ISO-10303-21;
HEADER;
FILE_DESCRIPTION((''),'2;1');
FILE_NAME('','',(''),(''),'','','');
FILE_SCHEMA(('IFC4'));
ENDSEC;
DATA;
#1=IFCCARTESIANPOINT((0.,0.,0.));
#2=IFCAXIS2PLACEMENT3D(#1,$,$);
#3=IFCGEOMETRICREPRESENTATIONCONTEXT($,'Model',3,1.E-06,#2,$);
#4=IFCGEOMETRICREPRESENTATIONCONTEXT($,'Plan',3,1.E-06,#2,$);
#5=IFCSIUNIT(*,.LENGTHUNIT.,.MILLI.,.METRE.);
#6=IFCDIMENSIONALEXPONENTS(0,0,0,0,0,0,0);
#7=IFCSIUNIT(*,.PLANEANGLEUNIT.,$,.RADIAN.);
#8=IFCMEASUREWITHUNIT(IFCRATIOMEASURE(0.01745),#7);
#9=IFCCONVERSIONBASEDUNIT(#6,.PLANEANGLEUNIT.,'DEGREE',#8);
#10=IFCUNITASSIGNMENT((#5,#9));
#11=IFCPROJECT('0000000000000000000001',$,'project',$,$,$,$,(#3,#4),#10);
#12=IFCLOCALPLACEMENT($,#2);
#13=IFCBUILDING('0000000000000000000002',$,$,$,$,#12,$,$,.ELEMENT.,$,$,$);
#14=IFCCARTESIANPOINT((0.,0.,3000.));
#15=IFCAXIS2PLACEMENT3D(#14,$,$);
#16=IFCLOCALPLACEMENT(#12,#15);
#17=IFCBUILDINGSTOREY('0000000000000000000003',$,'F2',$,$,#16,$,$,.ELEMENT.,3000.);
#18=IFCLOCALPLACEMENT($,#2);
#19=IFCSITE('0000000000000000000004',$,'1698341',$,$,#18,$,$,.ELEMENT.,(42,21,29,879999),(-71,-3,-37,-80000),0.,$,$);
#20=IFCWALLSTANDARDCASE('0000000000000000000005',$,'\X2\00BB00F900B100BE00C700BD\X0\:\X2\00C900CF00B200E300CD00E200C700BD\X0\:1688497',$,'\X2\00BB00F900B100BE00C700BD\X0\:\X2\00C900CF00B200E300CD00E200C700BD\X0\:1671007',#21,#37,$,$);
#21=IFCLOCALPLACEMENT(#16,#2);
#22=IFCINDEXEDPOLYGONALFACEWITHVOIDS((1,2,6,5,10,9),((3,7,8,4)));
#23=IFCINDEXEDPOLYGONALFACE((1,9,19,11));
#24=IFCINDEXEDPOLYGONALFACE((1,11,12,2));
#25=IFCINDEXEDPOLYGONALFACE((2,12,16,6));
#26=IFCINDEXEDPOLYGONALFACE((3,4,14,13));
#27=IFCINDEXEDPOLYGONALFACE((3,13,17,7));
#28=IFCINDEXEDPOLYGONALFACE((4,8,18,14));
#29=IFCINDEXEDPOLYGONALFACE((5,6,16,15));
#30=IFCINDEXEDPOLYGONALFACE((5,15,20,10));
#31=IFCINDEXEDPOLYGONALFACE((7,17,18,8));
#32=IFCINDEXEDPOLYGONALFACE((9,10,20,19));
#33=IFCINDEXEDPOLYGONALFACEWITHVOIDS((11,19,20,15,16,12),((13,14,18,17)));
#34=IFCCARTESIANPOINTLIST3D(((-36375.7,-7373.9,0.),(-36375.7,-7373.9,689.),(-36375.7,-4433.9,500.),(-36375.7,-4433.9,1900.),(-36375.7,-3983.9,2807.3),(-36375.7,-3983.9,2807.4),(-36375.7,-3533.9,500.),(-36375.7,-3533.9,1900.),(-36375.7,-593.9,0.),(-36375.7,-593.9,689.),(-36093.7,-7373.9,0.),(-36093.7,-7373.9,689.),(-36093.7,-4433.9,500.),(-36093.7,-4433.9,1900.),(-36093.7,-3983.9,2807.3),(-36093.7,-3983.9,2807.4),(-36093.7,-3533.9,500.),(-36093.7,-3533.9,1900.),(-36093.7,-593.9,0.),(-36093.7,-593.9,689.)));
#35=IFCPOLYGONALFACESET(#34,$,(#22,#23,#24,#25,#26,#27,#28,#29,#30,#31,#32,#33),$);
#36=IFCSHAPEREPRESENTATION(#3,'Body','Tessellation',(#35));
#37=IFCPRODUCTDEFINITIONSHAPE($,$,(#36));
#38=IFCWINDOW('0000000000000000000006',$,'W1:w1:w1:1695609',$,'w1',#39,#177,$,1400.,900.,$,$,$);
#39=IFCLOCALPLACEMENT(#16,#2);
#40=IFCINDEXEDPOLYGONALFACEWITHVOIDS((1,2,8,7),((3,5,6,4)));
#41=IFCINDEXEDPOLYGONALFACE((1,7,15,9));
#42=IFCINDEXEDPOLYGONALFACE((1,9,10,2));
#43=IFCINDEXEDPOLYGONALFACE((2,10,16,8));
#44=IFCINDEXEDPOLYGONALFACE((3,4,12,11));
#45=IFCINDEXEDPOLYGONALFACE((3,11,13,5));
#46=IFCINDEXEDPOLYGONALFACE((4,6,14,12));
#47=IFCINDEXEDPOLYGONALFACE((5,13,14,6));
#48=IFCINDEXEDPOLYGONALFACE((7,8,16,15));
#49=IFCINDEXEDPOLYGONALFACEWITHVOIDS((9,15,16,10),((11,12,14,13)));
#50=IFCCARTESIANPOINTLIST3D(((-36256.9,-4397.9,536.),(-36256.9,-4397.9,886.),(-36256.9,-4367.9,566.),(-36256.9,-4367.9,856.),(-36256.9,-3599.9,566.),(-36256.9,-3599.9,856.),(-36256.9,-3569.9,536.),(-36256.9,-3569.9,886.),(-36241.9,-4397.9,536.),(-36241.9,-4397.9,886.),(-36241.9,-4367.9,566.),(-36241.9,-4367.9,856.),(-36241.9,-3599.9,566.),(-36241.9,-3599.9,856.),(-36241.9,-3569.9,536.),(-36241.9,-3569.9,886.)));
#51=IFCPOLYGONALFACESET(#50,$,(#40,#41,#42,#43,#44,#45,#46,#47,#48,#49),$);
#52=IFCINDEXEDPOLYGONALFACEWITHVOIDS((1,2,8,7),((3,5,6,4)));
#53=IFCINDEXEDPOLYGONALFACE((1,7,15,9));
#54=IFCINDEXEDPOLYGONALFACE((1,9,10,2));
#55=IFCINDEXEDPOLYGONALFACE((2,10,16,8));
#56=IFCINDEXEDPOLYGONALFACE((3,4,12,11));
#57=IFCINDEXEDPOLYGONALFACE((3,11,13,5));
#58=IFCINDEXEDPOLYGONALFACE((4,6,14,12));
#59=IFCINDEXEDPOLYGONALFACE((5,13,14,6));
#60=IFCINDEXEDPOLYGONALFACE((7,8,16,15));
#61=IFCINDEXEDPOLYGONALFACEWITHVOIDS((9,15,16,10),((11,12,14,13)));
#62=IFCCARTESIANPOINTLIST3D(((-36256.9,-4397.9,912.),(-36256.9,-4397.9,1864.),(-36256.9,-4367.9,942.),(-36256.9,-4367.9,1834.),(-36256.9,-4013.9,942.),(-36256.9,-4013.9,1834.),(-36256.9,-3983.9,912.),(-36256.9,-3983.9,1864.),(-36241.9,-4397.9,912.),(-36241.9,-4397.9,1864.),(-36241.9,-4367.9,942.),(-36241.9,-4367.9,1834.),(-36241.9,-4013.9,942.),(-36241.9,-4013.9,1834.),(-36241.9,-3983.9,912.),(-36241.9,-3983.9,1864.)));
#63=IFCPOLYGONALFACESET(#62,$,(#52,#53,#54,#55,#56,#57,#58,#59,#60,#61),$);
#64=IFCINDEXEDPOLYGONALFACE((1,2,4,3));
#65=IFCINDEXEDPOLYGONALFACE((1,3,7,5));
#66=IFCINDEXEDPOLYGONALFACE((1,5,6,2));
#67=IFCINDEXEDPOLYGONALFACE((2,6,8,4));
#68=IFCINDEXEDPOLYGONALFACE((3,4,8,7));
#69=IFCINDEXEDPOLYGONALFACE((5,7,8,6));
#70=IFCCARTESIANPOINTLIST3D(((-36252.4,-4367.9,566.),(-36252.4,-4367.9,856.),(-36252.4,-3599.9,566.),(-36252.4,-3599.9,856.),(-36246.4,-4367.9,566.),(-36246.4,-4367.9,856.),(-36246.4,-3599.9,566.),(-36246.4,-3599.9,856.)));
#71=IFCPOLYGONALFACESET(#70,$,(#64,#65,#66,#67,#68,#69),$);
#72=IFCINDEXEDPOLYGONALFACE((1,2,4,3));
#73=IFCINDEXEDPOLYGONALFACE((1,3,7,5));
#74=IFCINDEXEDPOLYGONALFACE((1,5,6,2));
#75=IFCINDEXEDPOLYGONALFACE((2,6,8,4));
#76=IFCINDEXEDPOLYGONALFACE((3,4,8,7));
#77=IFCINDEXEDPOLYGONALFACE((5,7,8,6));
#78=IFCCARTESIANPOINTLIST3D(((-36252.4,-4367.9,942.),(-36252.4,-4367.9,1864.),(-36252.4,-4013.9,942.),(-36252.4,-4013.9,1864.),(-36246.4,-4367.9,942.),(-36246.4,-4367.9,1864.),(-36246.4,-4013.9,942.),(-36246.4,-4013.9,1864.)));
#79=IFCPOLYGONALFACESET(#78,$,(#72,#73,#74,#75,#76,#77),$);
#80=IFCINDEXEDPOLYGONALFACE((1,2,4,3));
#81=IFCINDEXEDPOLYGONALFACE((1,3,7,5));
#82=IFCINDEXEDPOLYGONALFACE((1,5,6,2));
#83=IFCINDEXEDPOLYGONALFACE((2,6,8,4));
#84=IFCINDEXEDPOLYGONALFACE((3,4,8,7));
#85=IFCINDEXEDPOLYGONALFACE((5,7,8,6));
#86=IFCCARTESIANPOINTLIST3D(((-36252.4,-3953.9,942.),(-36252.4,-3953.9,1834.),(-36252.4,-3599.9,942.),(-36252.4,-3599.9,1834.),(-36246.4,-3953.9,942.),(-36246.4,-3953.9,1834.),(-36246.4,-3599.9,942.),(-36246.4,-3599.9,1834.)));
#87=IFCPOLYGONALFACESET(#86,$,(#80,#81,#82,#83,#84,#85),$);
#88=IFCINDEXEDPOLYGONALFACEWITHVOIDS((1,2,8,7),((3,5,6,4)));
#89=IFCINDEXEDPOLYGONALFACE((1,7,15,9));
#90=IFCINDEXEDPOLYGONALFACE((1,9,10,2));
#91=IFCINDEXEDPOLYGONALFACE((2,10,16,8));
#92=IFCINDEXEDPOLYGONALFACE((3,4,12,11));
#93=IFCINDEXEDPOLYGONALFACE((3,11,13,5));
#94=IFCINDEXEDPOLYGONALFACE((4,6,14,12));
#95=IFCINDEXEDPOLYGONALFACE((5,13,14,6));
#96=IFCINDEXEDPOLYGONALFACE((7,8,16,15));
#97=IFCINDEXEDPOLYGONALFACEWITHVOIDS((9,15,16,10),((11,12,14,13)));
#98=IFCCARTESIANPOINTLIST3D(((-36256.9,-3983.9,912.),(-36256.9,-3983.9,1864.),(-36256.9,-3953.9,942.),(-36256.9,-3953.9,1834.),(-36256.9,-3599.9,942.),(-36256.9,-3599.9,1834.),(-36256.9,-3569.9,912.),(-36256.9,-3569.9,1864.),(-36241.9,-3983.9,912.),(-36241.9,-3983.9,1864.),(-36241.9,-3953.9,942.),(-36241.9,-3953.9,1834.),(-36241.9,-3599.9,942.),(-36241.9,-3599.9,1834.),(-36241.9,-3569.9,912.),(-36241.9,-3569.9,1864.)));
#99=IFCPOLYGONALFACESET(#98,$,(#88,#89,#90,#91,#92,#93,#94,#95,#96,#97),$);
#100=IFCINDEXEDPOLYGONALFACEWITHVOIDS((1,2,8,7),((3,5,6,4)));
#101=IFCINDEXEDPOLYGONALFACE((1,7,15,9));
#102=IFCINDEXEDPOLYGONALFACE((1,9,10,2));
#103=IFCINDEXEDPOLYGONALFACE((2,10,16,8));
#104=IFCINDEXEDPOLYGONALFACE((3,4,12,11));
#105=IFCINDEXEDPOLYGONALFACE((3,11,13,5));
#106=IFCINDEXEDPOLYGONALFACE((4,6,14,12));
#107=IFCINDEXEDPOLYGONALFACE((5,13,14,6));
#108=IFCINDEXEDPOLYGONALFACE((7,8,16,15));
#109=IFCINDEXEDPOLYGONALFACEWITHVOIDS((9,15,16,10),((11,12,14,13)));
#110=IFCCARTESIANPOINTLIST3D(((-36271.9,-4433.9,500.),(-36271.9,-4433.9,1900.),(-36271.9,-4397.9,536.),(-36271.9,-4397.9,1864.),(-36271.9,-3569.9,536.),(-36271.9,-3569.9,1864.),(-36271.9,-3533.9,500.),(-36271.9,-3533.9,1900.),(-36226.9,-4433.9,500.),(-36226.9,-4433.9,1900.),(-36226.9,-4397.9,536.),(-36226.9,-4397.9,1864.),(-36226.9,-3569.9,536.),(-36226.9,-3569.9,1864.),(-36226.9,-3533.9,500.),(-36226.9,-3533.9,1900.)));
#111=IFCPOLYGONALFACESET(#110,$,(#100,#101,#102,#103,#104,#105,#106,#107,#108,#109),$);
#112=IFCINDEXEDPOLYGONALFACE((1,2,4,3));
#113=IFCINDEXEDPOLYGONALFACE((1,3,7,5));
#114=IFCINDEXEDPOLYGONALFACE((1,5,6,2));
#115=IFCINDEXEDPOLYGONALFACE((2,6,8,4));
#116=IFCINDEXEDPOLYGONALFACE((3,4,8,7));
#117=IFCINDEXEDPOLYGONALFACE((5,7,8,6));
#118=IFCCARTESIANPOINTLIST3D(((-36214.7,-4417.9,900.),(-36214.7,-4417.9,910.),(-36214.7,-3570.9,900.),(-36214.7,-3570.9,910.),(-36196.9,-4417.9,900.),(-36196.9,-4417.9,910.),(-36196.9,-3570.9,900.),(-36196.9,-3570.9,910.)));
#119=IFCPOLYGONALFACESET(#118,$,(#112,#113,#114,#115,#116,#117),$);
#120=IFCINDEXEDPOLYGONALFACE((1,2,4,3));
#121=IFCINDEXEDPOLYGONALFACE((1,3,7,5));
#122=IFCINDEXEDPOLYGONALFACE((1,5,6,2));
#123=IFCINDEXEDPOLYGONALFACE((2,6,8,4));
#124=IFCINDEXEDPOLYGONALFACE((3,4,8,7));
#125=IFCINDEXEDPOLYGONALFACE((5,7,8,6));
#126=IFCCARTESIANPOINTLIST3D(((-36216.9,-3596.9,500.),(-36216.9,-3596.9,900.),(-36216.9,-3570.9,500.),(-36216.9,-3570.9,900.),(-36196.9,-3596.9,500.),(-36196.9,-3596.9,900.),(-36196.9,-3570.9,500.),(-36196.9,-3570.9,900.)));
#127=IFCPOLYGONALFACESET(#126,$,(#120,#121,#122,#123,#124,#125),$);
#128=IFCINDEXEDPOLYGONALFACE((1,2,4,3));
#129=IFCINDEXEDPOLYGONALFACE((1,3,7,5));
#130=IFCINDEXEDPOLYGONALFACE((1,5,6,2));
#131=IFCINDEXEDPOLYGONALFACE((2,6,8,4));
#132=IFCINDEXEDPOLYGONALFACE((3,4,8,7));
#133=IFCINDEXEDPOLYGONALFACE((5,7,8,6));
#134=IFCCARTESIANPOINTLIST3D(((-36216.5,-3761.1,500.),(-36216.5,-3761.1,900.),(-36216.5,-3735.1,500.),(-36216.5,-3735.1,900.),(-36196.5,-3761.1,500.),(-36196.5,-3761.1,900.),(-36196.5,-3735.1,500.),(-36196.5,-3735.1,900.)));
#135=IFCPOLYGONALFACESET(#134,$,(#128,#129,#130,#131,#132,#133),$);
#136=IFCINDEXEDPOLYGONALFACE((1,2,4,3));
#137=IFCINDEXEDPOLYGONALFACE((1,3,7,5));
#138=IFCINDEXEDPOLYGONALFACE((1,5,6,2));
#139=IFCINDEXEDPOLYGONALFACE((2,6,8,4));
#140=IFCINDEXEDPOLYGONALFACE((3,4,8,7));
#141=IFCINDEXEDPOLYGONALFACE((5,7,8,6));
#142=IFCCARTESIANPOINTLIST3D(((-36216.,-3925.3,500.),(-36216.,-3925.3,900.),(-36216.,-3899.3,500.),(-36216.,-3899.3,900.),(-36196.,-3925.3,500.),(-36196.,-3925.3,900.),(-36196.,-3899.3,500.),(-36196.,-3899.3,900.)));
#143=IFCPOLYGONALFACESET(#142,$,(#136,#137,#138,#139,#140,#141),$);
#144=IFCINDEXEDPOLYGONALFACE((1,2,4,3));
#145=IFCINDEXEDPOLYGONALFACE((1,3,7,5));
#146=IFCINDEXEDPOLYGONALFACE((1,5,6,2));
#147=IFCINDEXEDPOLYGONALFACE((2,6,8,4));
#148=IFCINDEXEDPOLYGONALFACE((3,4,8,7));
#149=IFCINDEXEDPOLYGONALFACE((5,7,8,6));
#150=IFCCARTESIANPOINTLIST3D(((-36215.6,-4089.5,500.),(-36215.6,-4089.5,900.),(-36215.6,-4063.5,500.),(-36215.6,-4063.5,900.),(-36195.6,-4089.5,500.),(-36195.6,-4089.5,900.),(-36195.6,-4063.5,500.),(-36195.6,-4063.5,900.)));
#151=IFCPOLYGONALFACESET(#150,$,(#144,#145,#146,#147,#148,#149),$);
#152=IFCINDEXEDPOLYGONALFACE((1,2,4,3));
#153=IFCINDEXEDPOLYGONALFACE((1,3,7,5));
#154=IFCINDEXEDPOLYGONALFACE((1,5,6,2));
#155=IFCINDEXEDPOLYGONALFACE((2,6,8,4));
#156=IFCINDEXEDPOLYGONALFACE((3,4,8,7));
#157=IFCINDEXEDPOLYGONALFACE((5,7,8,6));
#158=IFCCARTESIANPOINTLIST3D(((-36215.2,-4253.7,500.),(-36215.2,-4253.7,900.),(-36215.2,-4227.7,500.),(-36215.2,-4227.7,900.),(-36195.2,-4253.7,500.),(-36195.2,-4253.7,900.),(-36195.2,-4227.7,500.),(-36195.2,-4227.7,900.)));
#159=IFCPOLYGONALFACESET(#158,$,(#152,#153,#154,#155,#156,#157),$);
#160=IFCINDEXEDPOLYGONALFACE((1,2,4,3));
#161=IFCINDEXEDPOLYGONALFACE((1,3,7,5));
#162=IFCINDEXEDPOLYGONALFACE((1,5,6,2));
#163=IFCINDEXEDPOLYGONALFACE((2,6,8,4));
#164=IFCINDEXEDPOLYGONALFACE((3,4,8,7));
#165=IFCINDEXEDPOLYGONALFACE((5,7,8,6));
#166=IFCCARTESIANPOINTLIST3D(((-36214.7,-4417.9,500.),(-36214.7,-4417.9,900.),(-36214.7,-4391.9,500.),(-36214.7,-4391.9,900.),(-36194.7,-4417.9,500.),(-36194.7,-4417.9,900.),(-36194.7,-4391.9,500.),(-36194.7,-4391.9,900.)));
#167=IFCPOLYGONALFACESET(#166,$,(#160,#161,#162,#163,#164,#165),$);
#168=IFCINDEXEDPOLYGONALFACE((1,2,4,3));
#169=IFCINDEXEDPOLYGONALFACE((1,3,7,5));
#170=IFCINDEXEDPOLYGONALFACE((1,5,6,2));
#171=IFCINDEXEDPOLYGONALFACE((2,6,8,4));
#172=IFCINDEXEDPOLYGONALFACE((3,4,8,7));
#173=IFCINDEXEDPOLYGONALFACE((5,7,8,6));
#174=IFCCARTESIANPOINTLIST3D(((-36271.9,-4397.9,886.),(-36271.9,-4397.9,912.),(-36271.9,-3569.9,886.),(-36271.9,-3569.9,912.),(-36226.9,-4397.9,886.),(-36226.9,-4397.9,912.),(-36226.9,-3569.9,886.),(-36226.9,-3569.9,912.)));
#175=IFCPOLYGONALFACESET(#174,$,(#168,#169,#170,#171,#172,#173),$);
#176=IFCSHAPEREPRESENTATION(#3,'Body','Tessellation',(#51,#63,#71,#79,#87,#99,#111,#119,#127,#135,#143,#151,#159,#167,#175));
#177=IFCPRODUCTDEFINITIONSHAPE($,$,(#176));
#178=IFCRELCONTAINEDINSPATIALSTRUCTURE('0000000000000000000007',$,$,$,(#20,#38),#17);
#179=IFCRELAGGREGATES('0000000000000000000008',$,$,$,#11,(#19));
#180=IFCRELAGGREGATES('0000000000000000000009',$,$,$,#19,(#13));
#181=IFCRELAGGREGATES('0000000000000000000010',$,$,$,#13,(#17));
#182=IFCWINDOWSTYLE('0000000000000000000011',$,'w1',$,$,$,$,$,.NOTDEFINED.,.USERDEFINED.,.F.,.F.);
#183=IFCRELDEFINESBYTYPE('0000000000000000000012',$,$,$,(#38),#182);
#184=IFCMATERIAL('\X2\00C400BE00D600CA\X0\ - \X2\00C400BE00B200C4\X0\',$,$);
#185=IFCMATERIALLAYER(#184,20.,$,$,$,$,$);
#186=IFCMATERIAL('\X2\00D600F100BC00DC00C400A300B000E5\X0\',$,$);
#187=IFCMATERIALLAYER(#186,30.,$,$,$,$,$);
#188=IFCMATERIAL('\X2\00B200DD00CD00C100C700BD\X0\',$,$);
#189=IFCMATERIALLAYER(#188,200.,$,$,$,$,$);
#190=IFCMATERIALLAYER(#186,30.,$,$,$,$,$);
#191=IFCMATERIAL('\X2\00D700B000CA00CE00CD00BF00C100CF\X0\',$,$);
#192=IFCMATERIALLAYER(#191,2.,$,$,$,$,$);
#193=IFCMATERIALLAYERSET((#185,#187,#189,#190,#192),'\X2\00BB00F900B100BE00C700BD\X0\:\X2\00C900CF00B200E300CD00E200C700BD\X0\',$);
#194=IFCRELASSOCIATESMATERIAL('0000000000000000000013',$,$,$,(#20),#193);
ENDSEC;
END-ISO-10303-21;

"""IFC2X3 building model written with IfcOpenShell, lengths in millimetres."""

from ifc_helpers import new_model, entity, si_unit, converted_unit, frame, frame_2d, origin, origin_2d_with_axis, place, context, project, spatial, polyline, rectangle, outline, extrude, clip, bounded_halfspace, source, transform, mapped, material, layer, layer_set, layer_usage, type_object, type_shapes, element, fill, save


model = new_model("IFC2X3")

# Units and contexts
model_context = context("Model", 3, precision=1e-06, world=origin())
plan_context = context("Plan", 3, precision=1e-06, world=origin())
ifc_project = project(units=[si_unit("LENGTHUNIT", "METRE", prefix="MILLI"), converted_unit("PLANEANGLEUNIT", "DEGREE", entity("IfcRatioMeasure", 0.01745), si_unit("PLANEANGLEUNIT", "RADIAN"), dimensions=[0, 0, 0, 0, 0, 0, 0])], contexts=[model_context, plan_context])

# Site, building, storey
site_placement = place(None, origin())
site = spatial("IfcSite", under=ifc_project, at=site_placement, Name="1698341", CompositionType="ELEMENT", RefLatitude=(42, 21, 29, 879999), RefLongitude=(-71, -3, -37, -80000), RefElevation=0.0)
building_placement = place(None, origin())
building = spatial("IfcBuilding", under=site, at=building_placement, CompositionType="ELEMENT")
storey_placement = place(building_placement, frame((0.0, 0.0, 3000.0)))
storey = spatial("IfcBuildingStorey", under=building, at=storey_placement, Name="F2", CompositionType="ELEMENT", Elevation=3000.0)

# Shared definitions
ifc_material_1 = material(Name="Öñ¼ÜÄ£°å")

# Wall, opening, window
ifc_material_2 = material(Name="Ä¾ÖÊ - Ä¾²Ä")
ifc_layer_1 = layer(ifc_material_2, 20.0)
ifc_layer_2 = layer(ifc_material_1, 30.0)
ifc_material_3 = material(Name="²ÝÍÁÇ½")
ifc_layer_3 = layer(ifc_material_3, 200.0)
ifc_layer_4 = layer(ifc_material_1, 30.0)
ifc_material_4 = material(Name="×°ÊÎÍ¿ÁÏ")
ifc_layer_5 = layer(ifc_material_4, 2.0)
ifc_layer_set_1 = layer_set([ifc_layer_1, ifc_layer_2, ifc_layer_3, ifc_layer_4, ifc_layer_5], Name="»ù±¾Ç½:ÉÏ²ãÍâÇ½")
ifc_layer_usage_1 = layer_usage(ifc_layer_set_1, "AXIS2", "NEGATIVE", 141.0)
wall_1_placement = place(storey_placement, frame((-36234.7, -7373.9, 0.0), z_axis=(0.0, 0.0, 1.0), x_axis=(0.0, 1.0, 0.0)))
wall_1 = element("IfcWallStandardCase", 1, at=wall_1_placement, inside=storey, material=ifc_layer_usage_1, Name="»ù±¾Ç½:ÉÏ²ãÍâÇ½:1688497", ObjectType="»ù±¾Ç½:ÉÏ²ãÍâÇ½:1671007", context=model_context, shape_type="Clipping", body=[
    clip(clip(extrude(rectangle(XDim=6780.0, YDim=282.0, at=frame_2d((3390.0, 0.0), x_axis=(-1.0, 0.0))), origin(), (0.0, 0.0, 1.0), 3200.0), bounded_halfspace(frame((3390.0, -141.0, 2807.3), z_axis=(0.5299, 0.0, 0.848), x_axis=(0.0, 1.0, 0.0)), False, frame((3390.0, -141.0, 2807.3)), polyline([(0.0, 0.0), (3390.0, 0.0), (3390.0, 282.0), (0.0, 282.0), (0.0, 0.0)]))), bounded_halfspace(frame((0.0, -141.0, 689.0), z_axis=(-0.5299, 0.0, 0.848), x_axis=(0.0, -1.0, 0.0)), False, frame((0.0, -141.0, 689.0)), polyline([(0.0, 0.0), (3390.0, 0.0), (3390.0, 282.0), (0.0, 282.0), (0.0, 0.0)]))),
])
opening_1_placement = place(wall_1_placement, frame((2940.0, -141.0, 500.0)))
opening_1 = element("IfcOpeningElement", 2, at=opening_1_placement, cuts=wall_1, ObjectType="Opening", context=model_context, shape_type="SweptSolid", body=[
    extrude(rectangle(XDim=1400.0, YDim=900.0, at=frame_2d((700.0, 450.0), x_axis=(-1.0, 0.0))), frame((0.0, 0.0, 0.0), z_axis=(0.0, 1.0, 0.0), x_axis=(0.0, 0.0, 1.0)), (0.0, 0.0, 1.0), 282.0),
])
window_style_1 = type_object("IfcWindowStyle", Name="w1", ConstructionType="NOTDEFINED", OperationType="USERDEFINED", ParameterTakesPrecedence=False, Sizeable=False)
shared_shape_1 = source(origin(), model_context, "Body", "SweptSolid", [
    extrude(outline(polyline([(-175.0, -414.0), (175.0, -414.0), (175.0, 414.0), (-175.0, 414.0), (-175.0, -414.0)]), holes=[polyline([(145.0, -384.0), (-145.0, -384.0), (-145.0, 384.0), (145.0, 384.0), (145.0, -384.0)])]), frame((450.0, 148.1, 211.0), z_axis=(0.0, 1.0, 0.0), x_axis=(0.0, 0.0, 1.0)), (0.0, 0.0, 1.0), 15.0),
    extrude(outline(polyline([(-476.0, -207.0), (476.0, -207.0), (476.0, 207.0), (-476.0, 207.0), (-476.0, -207.0)]), holes=[polyline([(446.0, -177.0), (-446.0, -177.0), (-446.0, 177.0), (446.0, 177.0), (446.0, -177.0)])]), frame((243.0, 148.1, 888.0), z_axis=(0.0, 1.0, 0.0), x_axis=(0.0, 0.0, 1.0)), (0.0, 0.0, 1.0), 15.0),
    extrude(rectangle(XDim=6.0, YDim=768.0, at=origin_2d_with_axis()), frame((450.0, 155.6, 66.0), z_axis=(0.0, 0.0, 1.0), x_axis=(0.0, 1.0, 0.0)), (0.0, 0.0, 1.0), 290.0),
    extrude(rectangle(XDim=6.0, YDim=354.0, at=origin_2d_with_axis()), frame((243.0, 155.6, 442.0), z_axis=(0.0, 0.0, 1.0), x_axis=(0.0, 1.0, 0.0)), (0.0, 0.0, 1.0), 922.0),
    extrude(rectangle(XDim=6.0, YDim=354.0, at=origin_2d_with_axis()), frame((657.0, 155.6, 442.0), z_axis=(0.0, 0.0, 1.0), x_axis=(0.0, 1.0, 0.0)), (0.0, 0.0, 1.0), 892.0),
    extrude(outline(polyline([(-476.0, -207.0), (476.0, -207.0), (476.0, 207.0), (-476.0, 207.0), (-476.0, -207.0)]), holes=[polyline([(446.0, -177.0), (-446.0, -177.0), (-446.0, 177.0), (446.0, 177.0), (446.0, -177.0)])]), frame((657.0, 148.1, 888.0), z_axis=(0.0, 1.0, 0.0), x_axis=(0.0, 0.0, 1.0)), (0.0, 0.0, 1.0), 15.0),
    extrude(outline(polyline([(-700.0, -450.0), (700.0, -450.0), (700.0, 450.0), (-700.0, 450.0), (-700.0, -450.0)]), holes=[polyline([(664.0, -414.0), (-664.0, -414.0), (-664.0, 414.0), (664.0, 414.0), (664.0, -414.0)])]), frame((450.0, 133.1, 700.0), z_axis=(0.0, 1.0, 0.0), x_axis=(0.0, 0.0, 1.0)), (0.0, 0.0, 1.0), 45.0),
    extrude(rectangle(XDim=847.1, YDim=17.9, at=origin_2d_with_axis()), frame((439.5, 112.1, 400.0), z_axis=(0.0, 0.0, 1.0), x_axis=(-1.0, 0.0, 0.0)), (0.0, 0.0, 1.0), 10.0),
    extrude(rectangle(XDim=26.0, YDim=20.0, at=origin_2d_with_axis()), frame((850.0, 113.1, 0.0), z_axis=(0.0, 0.0, 1.0), x_axis=(-1.0, 0.0, 0.0)), (0.0, 0.0, 1.0), 400.0),
    extrude(rectangle(XDim=26.0, YDim=20.0, at=origin_2d_with_axis()), frame((685.8, 112.7, 0.0), z_axis=(0.0, 0.0, 1.0), x_axis=(-1.0, 0.0, 0.0)), (0.0, 0.0, 1.0), 400.0),
    extrude(rectangle(XDim=26.0, YDim=20.0, at=origin_2d_with_axis()), frame((521.6, 112.3, 0.0), z_axis=(0.0, 0.0, 1.0), x_axis=(-1.0, 0.0, 0.0)), (0.0, 0.0, 1.0), 400.0),
    extrude(rectangle(XDim=26.0, YDim=20.0, at=origin_2d_with_axis()), frame((357.4, 111.9, 0.0), z_axis=(0.0, 0.0, 1.0), x_axis=(-1.0, 0.0, 0.0)), (0.0, 0.0, 1.0), 400.0),
    extrude(rectangle(XDim=26.0, YDim=20.0, at=origin_2d_with_axis()), frame((193.2, 111.4, 0.0), z_axis=(0.0, 0.0, 1.0), x_axis=(-1.0, 0.0, 0.0)), (0.0, 0.0, 1.0), 400.0),
    extrude(rectangle(XDim=26.0, YDim=20.0, at=origin_2d_with_axis()), frame((28.9, 111.0, 0.0), z_axis=(0.0, 0.0, 1.0), x_axis=(-1.0, 0.0, 0.0)), (0.0, 0.0, 1.0), 400.0),
    extrude(rectangle(XDim=45.0, YDim=828.0, at=origin_2d_with_axis()), frame((450.0, 155.6, 386.0), z_axis=(0.0, 0.0, 1.0), x_axis=(0.0, 1.0, 0.0)), (0.0, 0.0, 1.0), 26.0),
])
type_shapes(window_style_1, [shared_shape_1])
window_1_placement = place(opening_1_placement, origin())
window_1 = element("IfcWindow", 3, at=window_1_placement, inside=storey, type_object=window_style_1, Name="W1:w1:w1:1695609", ObjectType="w1", OverallHeight=1400.0, OverallWidth=900.0, context=model_context, shape_type="MappedRepresentation", body=[
    mapped(shared_shape_1, transform((0.0, 0.0, 0.0), scale=1.0)),
])
fill(opening_1, window_1)

save(model, "model.ifc")
